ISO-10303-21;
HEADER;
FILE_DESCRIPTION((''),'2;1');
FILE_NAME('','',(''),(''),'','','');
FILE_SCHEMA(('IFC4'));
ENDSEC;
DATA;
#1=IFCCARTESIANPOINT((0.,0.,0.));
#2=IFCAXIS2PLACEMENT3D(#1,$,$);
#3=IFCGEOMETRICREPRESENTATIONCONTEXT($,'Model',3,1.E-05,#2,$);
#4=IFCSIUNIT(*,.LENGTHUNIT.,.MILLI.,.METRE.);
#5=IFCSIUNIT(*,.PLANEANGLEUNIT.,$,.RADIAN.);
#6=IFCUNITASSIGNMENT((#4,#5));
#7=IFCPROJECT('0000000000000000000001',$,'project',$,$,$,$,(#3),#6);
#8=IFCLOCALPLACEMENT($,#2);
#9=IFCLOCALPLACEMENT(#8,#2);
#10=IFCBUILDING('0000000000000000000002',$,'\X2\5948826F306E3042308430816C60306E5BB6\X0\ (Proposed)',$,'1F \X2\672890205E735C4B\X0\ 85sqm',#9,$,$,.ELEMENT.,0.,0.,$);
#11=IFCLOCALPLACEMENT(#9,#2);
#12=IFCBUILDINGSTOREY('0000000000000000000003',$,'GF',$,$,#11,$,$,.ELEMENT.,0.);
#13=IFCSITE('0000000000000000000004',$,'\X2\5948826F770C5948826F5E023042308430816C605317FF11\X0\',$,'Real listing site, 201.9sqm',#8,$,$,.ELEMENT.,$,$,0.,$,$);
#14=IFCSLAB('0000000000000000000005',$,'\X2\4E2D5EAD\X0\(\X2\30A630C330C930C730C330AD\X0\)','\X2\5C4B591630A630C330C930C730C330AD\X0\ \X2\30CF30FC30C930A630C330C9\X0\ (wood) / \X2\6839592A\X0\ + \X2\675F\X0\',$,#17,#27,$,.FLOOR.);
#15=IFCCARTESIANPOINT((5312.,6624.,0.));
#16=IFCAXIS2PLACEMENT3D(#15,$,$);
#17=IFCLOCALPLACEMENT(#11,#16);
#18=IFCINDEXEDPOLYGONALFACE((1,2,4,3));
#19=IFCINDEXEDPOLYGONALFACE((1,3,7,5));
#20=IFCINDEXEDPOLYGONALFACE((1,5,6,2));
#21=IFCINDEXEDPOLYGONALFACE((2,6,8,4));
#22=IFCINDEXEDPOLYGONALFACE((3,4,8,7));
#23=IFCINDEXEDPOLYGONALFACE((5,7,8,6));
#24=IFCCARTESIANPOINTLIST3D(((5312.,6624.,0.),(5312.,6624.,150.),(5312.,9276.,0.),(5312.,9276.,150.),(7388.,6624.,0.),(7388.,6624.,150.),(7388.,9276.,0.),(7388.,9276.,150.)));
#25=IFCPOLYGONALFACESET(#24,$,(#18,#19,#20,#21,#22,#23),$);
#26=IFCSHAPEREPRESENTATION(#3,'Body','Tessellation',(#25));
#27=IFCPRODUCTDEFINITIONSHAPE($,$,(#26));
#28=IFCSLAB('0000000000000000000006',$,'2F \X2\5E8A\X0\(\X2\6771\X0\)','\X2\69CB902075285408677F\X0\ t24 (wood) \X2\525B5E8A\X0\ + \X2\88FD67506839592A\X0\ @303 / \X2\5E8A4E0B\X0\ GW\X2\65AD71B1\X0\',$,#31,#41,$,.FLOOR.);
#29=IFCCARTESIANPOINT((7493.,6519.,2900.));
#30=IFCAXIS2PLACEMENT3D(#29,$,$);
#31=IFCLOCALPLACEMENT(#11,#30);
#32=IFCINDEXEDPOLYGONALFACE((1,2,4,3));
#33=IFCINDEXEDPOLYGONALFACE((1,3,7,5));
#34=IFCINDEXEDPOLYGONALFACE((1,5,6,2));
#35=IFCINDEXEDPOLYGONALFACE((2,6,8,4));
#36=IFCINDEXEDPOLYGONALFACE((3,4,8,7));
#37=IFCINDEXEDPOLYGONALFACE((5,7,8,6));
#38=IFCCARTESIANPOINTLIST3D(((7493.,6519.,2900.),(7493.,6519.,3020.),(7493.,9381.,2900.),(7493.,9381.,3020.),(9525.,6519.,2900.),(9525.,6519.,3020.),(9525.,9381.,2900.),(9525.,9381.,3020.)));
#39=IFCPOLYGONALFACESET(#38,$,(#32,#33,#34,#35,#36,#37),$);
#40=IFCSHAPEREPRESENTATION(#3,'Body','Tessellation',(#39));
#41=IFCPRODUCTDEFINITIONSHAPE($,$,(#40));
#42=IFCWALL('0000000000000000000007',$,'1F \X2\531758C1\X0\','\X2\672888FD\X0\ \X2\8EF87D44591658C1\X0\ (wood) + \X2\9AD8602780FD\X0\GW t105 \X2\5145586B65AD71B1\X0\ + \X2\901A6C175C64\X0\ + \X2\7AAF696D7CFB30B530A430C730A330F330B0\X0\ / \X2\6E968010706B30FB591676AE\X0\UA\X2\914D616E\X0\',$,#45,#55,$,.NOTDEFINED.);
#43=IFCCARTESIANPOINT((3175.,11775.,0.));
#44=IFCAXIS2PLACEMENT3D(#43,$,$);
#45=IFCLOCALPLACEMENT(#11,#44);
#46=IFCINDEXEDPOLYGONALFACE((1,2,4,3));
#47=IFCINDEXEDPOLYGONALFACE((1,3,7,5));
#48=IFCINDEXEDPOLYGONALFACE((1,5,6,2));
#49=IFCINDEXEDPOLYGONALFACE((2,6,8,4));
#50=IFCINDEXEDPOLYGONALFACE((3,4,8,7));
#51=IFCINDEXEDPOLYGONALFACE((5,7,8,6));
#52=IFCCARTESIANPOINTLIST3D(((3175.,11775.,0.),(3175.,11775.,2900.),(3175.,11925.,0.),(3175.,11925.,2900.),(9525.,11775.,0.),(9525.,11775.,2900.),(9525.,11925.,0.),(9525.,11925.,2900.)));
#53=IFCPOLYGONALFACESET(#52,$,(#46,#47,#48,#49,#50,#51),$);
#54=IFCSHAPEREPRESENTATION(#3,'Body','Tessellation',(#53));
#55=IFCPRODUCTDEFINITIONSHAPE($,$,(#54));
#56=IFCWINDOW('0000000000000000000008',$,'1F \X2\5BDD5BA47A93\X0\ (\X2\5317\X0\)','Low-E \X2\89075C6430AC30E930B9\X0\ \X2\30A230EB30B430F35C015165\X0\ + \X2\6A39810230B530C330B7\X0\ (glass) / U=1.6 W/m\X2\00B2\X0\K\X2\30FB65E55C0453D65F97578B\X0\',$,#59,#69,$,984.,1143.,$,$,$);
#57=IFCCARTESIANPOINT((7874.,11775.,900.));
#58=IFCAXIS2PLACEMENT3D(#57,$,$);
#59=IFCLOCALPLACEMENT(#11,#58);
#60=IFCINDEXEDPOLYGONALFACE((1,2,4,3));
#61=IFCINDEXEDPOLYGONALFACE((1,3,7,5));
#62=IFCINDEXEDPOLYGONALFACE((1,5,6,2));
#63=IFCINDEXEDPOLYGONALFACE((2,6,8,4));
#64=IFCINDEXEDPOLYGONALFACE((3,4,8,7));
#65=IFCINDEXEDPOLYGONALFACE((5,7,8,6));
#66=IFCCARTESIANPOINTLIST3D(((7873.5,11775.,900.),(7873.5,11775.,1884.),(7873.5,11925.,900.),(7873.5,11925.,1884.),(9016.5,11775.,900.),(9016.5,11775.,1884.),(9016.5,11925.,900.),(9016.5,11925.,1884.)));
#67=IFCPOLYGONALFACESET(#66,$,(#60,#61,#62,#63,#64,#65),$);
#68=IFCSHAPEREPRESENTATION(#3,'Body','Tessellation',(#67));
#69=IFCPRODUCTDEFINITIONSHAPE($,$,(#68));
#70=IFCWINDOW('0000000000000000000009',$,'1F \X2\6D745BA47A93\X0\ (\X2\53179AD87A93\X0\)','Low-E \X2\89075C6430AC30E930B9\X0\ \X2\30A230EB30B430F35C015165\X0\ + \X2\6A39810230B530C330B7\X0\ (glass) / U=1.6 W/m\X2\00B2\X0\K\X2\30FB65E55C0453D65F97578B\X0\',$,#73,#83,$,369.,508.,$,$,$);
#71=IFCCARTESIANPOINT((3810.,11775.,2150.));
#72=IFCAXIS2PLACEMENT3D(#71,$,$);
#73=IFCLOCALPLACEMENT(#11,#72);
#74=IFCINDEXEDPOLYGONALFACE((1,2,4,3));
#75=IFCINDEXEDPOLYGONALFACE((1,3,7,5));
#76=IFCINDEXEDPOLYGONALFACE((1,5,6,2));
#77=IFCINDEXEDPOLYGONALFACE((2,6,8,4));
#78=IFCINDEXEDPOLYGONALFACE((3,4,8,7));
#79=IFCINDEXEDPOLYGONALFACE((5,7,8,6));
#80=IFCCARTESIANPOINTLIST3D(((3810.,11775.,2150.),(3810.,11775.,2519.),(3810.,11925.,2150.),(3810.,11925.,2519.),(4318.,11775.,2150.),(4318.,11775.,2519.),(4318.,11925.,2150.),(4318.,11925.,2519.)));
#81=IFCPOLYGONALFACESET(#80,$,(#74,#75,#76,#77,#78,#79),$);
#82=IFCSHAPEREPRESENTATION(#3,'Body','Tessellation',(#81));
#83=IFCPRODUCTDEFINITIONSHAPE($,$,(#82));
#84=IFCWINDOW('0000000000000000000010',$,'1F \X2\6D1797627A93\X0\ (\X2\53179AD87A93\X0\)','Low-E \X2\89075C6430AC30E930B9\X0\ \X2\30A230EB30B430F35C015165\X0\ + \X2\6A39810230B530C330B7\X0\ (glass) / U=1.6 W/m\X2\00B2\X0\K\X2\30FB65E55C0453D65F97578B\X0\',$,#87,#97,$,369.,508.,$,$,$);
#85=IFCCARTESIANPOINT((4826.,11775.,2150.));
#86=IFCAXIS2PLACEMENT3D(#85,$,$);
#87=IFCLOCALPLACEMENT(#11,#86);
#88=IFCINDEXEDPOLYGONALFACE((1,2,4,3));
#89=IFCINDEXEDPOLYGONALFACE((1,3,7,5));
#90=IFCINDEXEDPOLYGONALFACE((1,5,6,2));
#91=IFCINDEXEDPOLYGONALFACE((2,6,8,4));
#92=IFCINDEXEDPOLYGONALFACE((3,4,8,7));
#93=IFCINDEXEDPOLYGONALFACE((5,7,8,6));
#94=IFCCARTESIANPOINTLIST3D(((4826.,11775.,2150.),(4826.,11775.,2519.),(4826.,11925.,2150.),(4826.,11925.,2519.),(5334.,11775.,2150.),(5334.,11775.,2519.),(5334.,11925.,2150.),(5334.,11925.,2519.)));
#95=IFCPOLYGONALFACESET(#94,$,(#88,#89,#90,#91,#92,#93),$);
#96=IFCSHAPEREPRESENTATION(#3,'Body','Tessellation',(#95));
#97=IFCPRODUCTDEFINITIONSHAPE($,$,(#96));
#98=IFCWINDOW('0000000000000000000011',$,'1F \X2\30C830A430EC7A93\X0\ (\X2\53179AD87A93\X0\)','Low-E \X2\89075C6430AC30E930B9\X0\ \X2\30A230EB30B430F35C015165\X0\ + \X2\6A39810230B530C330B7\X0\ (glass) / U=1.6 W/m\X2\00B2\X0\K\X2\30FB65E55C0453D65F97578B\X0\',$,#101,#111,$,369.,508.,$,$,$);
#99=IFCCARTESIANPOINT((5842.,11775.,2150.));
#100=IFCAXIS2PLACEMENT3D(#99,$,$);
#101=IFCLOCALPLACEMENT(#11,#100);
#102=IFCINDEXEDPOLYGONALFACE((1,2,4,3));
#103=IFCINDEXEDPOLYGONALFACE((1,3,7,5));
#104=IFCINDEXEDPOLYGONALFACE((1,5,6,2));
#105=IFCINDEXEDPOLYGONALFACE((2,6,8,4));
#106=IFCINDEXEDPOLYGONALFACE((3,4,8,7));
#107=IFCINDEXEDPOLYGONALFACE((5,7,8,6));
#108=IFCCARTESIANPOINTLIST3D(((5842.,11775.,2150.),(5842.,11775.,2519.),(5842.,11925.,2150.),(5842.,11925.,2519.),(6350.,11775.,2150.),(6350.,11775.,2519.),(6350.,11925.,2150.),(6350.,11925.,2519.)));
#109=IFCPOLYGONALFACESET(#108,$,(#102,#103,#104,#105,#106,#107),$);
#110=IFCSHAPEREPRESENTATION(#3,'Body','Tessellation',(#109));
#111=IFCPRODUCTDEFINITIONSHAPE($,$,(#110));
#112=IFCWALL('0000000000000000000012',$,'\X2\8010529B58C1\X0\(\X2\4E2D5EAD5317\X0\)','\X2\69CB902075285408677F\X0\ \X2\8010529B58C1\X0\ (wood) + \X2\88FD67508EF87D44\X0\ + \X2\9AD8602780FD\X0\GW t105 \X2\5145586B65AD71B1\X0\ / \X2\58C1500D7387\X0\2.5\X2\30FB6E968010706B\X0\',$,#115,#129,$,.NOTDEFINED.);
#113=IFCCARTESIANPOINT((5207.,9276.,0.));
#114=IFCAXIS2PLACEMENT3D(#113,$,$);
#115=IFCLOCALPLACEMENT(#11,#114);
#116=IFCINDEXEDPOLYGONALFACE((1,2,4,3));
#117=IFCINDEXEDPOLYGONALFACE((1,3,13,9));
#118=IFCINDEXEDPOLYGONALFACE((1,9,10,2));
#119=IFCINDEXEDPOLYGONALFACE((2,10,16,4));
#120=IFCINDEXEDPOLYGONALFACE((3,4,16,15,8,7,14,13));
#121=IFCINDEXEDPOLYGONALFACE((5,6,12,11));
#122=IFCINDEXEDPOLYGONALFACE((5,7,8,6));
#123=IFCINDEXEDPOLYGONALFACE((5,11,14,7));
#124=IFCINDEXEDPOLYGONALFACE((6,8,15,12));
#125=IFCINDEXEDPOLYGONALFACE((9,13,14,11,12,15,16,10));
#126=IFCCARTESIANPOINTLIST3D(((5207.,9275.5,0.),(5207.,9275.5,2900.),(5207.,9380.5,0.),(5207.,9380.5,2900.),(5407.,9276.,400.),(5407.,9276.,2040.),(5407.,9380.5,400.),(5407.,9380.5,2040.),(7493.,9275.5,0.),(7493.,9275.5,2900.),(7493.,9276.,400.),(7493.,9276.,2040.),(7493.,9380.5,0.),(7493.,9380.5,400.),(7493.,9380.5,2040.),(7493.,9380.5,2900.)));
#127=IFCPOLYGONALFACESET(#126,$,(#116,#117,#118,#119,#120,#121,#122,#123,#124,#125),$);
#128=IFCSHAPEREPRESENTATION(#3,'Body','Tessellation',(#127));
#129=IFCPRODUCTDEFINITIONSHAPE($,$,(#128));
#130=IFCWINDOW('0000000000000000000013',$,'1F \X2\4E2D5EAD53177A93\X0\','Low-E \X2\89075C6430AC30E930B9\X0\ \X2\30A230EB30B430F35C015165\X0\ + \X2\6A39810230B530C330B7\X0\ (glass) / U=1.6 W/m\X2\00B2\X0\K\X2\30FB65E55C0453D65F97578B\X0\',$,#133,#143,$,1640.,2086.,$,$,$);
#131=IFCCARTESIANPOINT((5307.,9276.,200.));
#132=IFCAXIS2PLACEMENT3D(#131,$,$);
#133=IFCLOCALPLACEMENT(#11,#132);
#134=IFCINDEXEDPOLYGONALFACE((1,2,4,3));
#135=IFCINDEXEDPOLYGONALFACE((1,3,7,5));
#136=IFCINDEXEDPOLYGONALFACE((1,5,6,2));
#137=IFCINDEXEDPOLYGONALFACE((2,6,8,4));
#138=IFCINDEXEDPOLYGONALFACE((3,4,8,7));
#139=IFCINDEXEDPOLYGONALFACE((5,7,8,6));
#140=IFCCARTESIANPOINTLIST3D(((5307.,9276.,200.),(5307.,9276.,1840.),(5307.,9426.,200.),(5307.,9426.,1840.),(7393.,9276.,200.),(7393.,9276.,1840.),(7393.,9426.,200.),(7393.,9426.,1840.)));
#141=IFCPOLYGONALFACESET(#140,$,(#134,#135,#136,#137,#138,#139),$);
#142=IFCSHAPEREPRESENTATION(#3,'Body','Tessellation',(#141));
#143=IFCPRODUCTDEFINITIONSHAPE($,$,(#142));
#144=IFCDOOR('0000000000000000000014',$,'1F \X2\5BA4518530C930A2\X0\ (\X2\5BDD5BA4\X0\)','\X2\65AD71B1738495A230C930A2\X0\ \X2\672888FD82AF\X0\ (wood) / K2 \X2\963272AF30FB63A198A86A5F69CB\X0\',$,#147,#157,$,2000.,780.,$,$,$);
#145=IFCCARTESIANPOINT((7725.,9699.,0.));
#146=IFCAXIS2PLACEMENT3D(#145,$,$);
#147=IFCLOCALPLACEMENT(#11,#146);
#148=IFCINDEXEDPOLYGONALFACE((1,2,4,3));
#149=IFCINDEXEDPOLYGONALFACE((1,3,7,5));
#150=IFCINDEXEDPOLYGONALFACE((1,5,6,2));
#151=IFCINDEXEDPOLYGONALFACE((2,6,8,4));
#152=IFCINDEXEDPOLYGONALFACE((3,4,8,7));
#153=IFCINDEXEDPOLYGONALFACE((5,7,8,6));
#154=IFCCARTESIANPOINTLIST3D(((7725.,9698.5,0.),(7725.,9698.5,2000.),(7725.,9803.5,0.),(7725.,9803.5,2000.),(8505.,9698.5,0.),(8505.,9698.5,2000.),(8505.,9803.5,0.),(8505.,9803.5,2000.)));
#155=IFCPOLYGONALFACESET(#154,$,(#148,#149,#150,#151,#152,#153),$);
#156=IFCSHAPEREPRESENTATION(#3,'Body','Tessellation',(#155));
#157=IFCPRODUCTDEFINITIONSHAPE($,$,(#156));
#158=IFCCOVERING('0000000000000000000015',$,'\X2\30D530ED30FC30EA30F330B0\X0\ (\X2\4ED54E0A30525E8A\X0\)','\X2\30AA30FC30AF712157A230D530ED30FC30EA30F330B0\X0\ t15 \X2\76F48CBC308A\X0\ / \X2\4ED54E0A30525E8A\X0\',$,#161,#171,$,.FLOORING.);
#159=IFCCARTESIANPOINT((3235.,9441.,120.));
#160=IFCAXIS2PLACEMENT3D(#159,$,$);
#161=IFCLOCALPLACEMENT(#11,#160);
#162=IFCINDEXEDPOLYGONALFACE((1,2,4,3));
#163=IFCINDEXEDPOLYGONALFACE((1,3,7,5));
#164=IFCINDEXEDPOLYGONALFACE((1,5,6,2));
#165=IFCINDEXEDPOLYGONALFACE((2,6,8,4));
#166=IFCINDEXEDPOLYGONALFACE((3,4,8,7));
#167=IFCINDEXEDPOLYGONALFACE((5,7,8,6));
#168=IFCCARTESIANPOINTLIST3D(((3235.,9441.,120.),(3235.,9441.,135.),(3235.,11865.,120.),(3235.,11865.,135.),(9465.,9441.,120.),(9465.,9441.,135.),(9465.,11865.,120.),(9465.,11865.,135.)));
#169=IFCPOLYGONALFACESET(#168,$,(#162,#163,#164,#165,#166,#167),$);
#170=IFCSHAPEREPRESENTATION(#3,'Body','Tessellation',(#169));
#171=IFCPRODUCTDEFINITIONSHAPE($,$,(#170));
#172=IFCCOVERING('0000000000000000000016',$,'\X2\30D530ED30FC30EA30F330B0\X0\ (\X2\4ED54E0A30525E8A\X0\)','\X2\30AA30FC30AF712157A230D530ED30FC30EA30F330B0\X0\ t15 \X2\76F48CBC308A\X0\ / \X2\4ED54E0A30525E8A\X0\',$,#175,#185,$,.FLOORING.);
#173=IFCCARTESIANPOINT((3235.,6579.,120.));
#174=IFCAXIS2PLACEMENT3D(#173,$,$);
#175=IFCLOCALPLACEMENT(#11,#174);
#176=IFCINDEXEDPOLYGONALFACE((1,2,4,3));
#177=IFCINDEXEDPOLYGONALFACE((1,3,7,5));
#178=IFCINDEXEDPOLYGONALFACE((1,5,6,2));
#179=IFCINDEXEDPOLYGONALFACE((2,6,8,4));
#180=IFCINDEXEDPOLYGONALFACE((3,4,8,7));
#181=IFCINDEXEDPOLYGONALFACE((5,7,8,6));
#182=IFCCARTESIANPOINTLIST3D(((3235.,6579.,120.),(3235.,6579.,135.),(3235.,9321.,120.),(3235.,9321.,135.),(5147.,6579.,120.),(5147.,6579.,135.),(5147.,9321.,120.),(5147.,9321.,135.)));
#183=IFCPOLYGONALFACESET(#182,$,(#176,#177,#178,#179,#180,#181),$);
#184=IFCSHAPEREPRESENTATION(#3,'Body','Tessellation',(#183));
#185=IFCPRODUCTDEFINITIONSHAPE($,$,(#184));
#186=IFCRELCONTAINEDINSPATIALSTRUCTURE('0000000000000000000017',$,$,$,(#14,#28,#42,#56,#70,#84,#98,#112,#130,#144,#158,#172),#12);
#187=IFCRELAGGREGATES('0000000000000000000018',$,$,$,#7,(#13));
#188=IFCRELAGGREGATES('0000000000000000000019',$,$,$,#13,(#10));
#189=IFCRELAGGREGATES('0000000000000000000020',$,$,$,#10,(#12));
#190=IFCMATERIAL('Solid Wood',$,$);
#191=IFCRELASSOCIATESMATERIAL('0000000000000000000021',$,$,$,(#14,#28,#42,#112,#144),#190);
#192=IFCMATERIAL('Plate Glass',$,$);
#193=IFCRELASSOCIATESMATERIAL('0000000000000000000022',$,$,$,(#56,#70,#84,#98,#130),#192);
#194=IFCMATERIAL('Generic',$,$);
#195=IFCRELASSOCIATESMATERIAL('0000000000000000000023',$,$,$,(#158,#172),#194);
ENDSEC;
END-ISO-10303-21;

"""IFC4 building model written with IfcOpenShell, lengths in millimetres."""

from ifc_helpers import new_model, si_unit, frame, frame_2d, origin, place, context, project, spatial, rectangle, extrude, material, element, fill, save


model = new_model("IFC4")

# Units and contexts
model_context = context("Model", 3, precision=1e-05, world=origin())
ifc_project = project(units=[si_unit("LENGTHUNIT", "METRE", prefix="MILLI"), si_unit("PLANEANGLEUNIT", "RADIAN")], contexts=[model_context])

# Site, building, storey
site_placement = place(None, origin())
site = spatial("IfcSite", under=ifc_project, at=site_placement, Name="奈良県奈良市あやめ池北１", ObjectType="Real listing site, 201.9sqm", CompositionType="ELEMENT", RefElevation=0.0)
building_placement = place(site_placement, origin())
building = spatial("IfcBuilding", under=site, at=building_placement, Name="奈良のあやめ池の家 (Proposed)", ObjectType="1F 木造平屋 85sqm", CompositionType="ELEMENT", ElevationOfRefHeight=0.0, ElevationOfTerrain=0.0)
storey_placement = place(building_placement, origin())
storey = spatial("IfcBuildingStorey", under=building, at=storey_placement, Name="GF", CompositionType="ELEMENT", Elevation=0.0)

# Slabs
ifc_material_1 = material(Name="Solid Wood")
slab_1_placement = place(storey_placement, frame((5312.0, 6624.0, 0.0)))
element("IfcSlab", 1, at=slab_1_placement, inside=storey, material=ifc_material_1, Name="中庭(ウッドデッキ)", Description="屋外ウッドデッキ ハードウッド (wood) / 根太 + 束", PredefinedType="FLOOR", context=model_context, shape_type="SweptSolid", body=[
    extrude(rectangle(XDim=2076.0, YDim=2652.0, at=frame_2d((1038.0, 1326.0))), frame((5312.0, 6624.0, 0.0)), (0.0, 0.0, 1.0), 150.0),
])
slab_2_placement = place(storey_placement, frame((7493.0, 6519.0, 2900.0)))
element("IfcSlab", 2, at=slab_2_placement, inside=storey, material=ifc_material_1, Name="2F 床(東)", Description="構造用合板 t24 (wood) 剛床 + 製材根太 @303 / 床下 GW断熱", PredefinedType="FLOOR", context=model_context, shape_type="SweptSolid", body=[
    extrude(rectangle(XDim=2032.0, YDim=2862.0, at=frame_2d((1016.0, 1431.0))), frame((7493.0, 6519.0, 2900.0)), (0.0, 0.0, 1.0), 120.0),
])

# Wall, openings, windows
wall_1_placement = place(storey_placement, frame((3175.0, 11775.0, 0.0)))
wall_1 = element("IfcWall", 3, at=wall_1_placement, inside=storey, material=ifc_material_1, Name="1F 北壁", Description="木製 軸組外壁 (wood) + 高性能GW t105 充填断熱 + 通気層 + 窯業系サイディング / 準耐火・外皮UA配慮", PredefinedType="NOTDEFINED", context=model_context, shape_type="SweptSolid", body=[
    extrude(rectangle(XDim=6350.0, YDim=150.0, at=frame_2d((3175.0, 75.0))), frame((3175.0, 11775.0, 0.0)), (0.0, 0.0, 1.0), 2900.0),
])
opening_1_placement = place(storey_placement, frame((7874.0, 11775.0, 900.0)))
opening_1 = element("IfcOpeningElement", 4, at=opening_1_placement, cuts=wall_1, PredefinedType="NOTDEFINED", context=model_context, shape_type="SweptSolid", body=[
    extrude(rectangle(XDim=1143.0, YDim=150.0, at=frame_2d((571.0, 75.0))), frame((7874.0, 11775.0, 900.0)), (0.0, 0.0, 1.0), 984.0),
])
opening_2_placement = place(storey_placement, frame((3810.0, 11775.0, 2150.0)))
opening_2 = element("IfcOpeningElement", 5, at=opening_2_placement, cuts=wall_1, PredefinedType="NOTDEFINED", context=model_context, shape_type="SweptSolid", body=[
    extrude(rectangle(XDim=508.0, YDim=150.0, at=frame_2d((254.0, 75.0))), frame((3810.0, 11775.0, 2150.0)), (0.0, 0.0, 1.0), 369.0),
])
opening_3_placement = place(storey_placement, frame((4826.0, 11775.0, 2150.0)))
opening_3 = element("IfcOpeningElement", 6, at=opening_3_placement, cuts=wall_1, PredefinedType="NOTDEFINED", context=model_context, shape_type="SweptSolid", body=[
    extrude(rectangle(XDim=508.0, YDim=150.0, at=frame_2d((254.0, 75.0))), frame((4826.0, 11775.0, 2150.0)), (0.0, 0.0, 1.0), 369.0),
])
opening_4_placement = place(storey_placement, frame((5842.0, 11775.0, 2150.0)))
opening_4 = element("IfcOpeningElement", 7, at=opening_4_placement, cuts=wall_1, PredefinedType="NOTDEFINED", context=model_context, shape_type="SweptSolid", body=[
    extrude(rectangle(XDim=508.0, YDim=150.0, at=frame_2d((254.0, 75.0))), frame((5842.0, 11775.0, 2150.0)), (0.0, 0.0, 1.0), 369.0),
])
ifc_material_2 = material(Name="Plate Glass")
window_1_placement = place(storey_placement, frame((7874.0, 11775.0, 900.0)))
window_1 = element("IfcWindow", 8, at=window_1_placement, inside=storey, material=ifc_material_2, Name="1F 寝室窓 (北)", Description="Low-E 複層ガラス アルゴン封入 + 樹脂サッシ (glass) / U=1.6 W/m²K・日射取得型", OverallHeight=984.0, OverallWidth=1143.0, context=model_context, shape_type="SweptSolid", body=[
    extrude(rectangle(XDim=1143.0, YDim=150.0, at=frame_2d((571.0, 75.0))), frame((7874.0, 11775.0, 900.0)), (0.0, 0.0, 1.0), 984.0),
])
fill(opening_1, window_1)
window_2_placement = place(storey_placement, frame((3810.0, 11775.0, 2150.0)))
window_2 = element("IfcWindow", 9, at=window_2_placement, inside=storey, material=ifc_material_2, Name="1F 浴室窓 (北高窓)", Description="Low-E 複層ガラス アルゴン封入 + 樹脂サッシ (glass) / U=1.6 W/m²K・日射取得型", OverallHeight=369.0, OverallWidth=508.0, context=model_context, shape_type="SweptSolid", body=[
    extrude(rectangle(XDim=508.0, YDim=150.0, at=frame_2d((254.0, 75.0))), frame((3810.0, 11775.0, 2150.0)), (0.0, 0.0, 1.0), 369.0),
])
fill(opening_2, window_2)
window_3_placement = place(storey_placement, frame((4826.0, 11775.0, 2150.0)))
window_3 = element("IfcWindow", 10, at=window_3_placement, inside=storey, material=ifc_material_2, Name="1F 洗面窓 (北高窓)", Description="Low-E 複層ガラス アルゴン封入 + 樹脂サッシ (glass) / U=1.6 W/m²K・日射取得型", OverallHeight=369.0, OverallWidth=508.0, context=model_context, shape_type="SweptSolid", body=[
    extrude(rectangle(XDim=508.0, YDim=150.0, at=frame_2d((254.0, 75.0))), frame((4826.0, 11775.0, 2150.0)), (0.0, 0.0, 1.0), 369.0),
])
fill(opening_3, window_3)
window_4_placement = place(storey_placement, frame((5842.0, 11775.0, 2150.0)))
window_4 = element("IfcWindow", 11, at=window_4_placement, inside=storey, material=ifc_material_2, Name="1F トイレ窓 (北高窓)", Description="Low-E 複層ガラス アルゴン封入 + 樹脂サッシ (glass) / U=1.6 W/m²K・日射取得型", OverallHeight=369.0, OverallWidth=508.0, context=model_context, shape_type="SweptSolid", body=[
    extrude(rectangle(XDim=508.0, YDim=150.0, at=frame_2d((254.0, 75.0))), frame((5842.0, 11775.0, 2150.0)), (0.0, 0.0, 1.0), 369.0),
])
fill(opening_4, window_4)

# Wall, opening, window
wall_2_placement = place(storey_placement, frame((5207.0, 9276.0, 0.0)))
wall_2 = element("IfcWall", 12, at=wall_2_placement, inside=storey, material=ifc_material_1, Name="耐力壁(中庭北)", Description="構造用合板 耐力壁 (wood) + 製材軸組 + 高性能GW t105 充填断熱 / 壁倍率2.5・準耐火", PredefinedType="NOTDEFINED", context=model_context, shape_type="SweptSolid", body=[
    extrude(rectangle(XDim=2286.0, YDim=105.0, at=frame_2d((1143.0, 52.0))), frame((5207.0, 9276.0, 0.0)), (0.0, 0.0, 1.0), 2900.0),
])
opening_5_placement = place(storey_placement, frame((5307.0, 9276.0, 200.0)))
opening_5 = element("IfcOpeningElement", 13, at=opening_5_placement, cuts=wall_2, PredefinedType="NOTDEFINED", context=model_context, shape_type="SweptSolid", body=[
    extrude(rectangle(XDim=2086.0, YDim=150.0, at=frame_2d((1043.0, 75.0))), frame((5307.0, 9276.0, 200.0)), (0.0, 0.0, 1.0), 1640.0),
])
window_5_placement = place(storey_placement, frame((5307.0, 9276.0, 200.0)))
window_5 = element("IfcWindow", 14, at=window_5_placement, inside=storey, material=ifc_material_2, Name="1F 中庭北窓", Description="Low-E 複層ガラス アルゴン封入 + 樹脂サッシ (glass) / U=1.6 W/m²K・日射取得型", OverallHeight=1640.0, OverallWidth=2086.0, context=model_context, shape_type="SweptSolid", body=[
    extrude(rectangle(XDim=2086.0, YDim=150.0, at=frame_2d((1043.0, 75.0))), frame((5307.0, 9276.0, 200.0)), (0.0, 0.0, 1.0), 1640.0),
])
fill(opening_5, window_5)

# Door
door_1_placement = place(storey_placement, frame((7725.0, 9699.0, 0.0)))
element("IfcDoor", 15, at=door_1_placement, inside=storey, material=ifc_material_1, Name="1F 室内ドア (寝室)", Description="断熱玄関ドア 木製芯 (wood) / K2 防犯・採風機構", OverallHeight=2000.0, OverallWidth=780.0, context=model_context, shape_type="SweptSolid", body=[
    extrude(rectangle(XDim=780.0, YDim=105.0, at=frame_2d((390.0, 52.0))), frame((7725.0, 9699.0, 0.0)), (0.0, 0.0, 1.0), 2000.0),
])

# Coverings
ifc_material_3 = material(Name="Generic")
covering_1_placement = place(storey_placement, frame((3235.0, 9441.0, 120.0)))
element("IfcCovering", 16, at=covering_1_placement, inside=storey, material=ifc_material_3, Name="フローリング (仕上げ床)", Description="オーク無垢フローリング t15 直貼り / 仕上げ床", PredefinedType="FLOORING", context=model_context, shape_type="SweptSolid", body=[
    extrude(rectangle(XDim=6230.0, YDim=2424.0, at=frame_2d((3115.0, 1212.0))), frame((3235.0, 9441.0, 120.0)), (0.0, 0.0, 1.0), 15.0),
])
covering_2_placement = place(storey_placement, frame((3235.0, 6579.0, 120.0)))
element("IfcCovering", 17, at=covering_2_placement, inside=storey, material=ifc_material_3, Name="フローリング (仕上げ床)", Description="オーク無垢フローリング t15 直貼り / 仕上げ床", PredefinedType="FLOORING", context=model_context, shape_type="SweptSolid", body=[
    extrude(rectangle(XDim=1912.0, YDim=2742.0, at=frame_2d((956.0, 1371.0))), frame((3235.0, 6579.0, 120.0)), (0.0, 0.0, 1.0), 15.0),
])

save(model, "model.ifc")
